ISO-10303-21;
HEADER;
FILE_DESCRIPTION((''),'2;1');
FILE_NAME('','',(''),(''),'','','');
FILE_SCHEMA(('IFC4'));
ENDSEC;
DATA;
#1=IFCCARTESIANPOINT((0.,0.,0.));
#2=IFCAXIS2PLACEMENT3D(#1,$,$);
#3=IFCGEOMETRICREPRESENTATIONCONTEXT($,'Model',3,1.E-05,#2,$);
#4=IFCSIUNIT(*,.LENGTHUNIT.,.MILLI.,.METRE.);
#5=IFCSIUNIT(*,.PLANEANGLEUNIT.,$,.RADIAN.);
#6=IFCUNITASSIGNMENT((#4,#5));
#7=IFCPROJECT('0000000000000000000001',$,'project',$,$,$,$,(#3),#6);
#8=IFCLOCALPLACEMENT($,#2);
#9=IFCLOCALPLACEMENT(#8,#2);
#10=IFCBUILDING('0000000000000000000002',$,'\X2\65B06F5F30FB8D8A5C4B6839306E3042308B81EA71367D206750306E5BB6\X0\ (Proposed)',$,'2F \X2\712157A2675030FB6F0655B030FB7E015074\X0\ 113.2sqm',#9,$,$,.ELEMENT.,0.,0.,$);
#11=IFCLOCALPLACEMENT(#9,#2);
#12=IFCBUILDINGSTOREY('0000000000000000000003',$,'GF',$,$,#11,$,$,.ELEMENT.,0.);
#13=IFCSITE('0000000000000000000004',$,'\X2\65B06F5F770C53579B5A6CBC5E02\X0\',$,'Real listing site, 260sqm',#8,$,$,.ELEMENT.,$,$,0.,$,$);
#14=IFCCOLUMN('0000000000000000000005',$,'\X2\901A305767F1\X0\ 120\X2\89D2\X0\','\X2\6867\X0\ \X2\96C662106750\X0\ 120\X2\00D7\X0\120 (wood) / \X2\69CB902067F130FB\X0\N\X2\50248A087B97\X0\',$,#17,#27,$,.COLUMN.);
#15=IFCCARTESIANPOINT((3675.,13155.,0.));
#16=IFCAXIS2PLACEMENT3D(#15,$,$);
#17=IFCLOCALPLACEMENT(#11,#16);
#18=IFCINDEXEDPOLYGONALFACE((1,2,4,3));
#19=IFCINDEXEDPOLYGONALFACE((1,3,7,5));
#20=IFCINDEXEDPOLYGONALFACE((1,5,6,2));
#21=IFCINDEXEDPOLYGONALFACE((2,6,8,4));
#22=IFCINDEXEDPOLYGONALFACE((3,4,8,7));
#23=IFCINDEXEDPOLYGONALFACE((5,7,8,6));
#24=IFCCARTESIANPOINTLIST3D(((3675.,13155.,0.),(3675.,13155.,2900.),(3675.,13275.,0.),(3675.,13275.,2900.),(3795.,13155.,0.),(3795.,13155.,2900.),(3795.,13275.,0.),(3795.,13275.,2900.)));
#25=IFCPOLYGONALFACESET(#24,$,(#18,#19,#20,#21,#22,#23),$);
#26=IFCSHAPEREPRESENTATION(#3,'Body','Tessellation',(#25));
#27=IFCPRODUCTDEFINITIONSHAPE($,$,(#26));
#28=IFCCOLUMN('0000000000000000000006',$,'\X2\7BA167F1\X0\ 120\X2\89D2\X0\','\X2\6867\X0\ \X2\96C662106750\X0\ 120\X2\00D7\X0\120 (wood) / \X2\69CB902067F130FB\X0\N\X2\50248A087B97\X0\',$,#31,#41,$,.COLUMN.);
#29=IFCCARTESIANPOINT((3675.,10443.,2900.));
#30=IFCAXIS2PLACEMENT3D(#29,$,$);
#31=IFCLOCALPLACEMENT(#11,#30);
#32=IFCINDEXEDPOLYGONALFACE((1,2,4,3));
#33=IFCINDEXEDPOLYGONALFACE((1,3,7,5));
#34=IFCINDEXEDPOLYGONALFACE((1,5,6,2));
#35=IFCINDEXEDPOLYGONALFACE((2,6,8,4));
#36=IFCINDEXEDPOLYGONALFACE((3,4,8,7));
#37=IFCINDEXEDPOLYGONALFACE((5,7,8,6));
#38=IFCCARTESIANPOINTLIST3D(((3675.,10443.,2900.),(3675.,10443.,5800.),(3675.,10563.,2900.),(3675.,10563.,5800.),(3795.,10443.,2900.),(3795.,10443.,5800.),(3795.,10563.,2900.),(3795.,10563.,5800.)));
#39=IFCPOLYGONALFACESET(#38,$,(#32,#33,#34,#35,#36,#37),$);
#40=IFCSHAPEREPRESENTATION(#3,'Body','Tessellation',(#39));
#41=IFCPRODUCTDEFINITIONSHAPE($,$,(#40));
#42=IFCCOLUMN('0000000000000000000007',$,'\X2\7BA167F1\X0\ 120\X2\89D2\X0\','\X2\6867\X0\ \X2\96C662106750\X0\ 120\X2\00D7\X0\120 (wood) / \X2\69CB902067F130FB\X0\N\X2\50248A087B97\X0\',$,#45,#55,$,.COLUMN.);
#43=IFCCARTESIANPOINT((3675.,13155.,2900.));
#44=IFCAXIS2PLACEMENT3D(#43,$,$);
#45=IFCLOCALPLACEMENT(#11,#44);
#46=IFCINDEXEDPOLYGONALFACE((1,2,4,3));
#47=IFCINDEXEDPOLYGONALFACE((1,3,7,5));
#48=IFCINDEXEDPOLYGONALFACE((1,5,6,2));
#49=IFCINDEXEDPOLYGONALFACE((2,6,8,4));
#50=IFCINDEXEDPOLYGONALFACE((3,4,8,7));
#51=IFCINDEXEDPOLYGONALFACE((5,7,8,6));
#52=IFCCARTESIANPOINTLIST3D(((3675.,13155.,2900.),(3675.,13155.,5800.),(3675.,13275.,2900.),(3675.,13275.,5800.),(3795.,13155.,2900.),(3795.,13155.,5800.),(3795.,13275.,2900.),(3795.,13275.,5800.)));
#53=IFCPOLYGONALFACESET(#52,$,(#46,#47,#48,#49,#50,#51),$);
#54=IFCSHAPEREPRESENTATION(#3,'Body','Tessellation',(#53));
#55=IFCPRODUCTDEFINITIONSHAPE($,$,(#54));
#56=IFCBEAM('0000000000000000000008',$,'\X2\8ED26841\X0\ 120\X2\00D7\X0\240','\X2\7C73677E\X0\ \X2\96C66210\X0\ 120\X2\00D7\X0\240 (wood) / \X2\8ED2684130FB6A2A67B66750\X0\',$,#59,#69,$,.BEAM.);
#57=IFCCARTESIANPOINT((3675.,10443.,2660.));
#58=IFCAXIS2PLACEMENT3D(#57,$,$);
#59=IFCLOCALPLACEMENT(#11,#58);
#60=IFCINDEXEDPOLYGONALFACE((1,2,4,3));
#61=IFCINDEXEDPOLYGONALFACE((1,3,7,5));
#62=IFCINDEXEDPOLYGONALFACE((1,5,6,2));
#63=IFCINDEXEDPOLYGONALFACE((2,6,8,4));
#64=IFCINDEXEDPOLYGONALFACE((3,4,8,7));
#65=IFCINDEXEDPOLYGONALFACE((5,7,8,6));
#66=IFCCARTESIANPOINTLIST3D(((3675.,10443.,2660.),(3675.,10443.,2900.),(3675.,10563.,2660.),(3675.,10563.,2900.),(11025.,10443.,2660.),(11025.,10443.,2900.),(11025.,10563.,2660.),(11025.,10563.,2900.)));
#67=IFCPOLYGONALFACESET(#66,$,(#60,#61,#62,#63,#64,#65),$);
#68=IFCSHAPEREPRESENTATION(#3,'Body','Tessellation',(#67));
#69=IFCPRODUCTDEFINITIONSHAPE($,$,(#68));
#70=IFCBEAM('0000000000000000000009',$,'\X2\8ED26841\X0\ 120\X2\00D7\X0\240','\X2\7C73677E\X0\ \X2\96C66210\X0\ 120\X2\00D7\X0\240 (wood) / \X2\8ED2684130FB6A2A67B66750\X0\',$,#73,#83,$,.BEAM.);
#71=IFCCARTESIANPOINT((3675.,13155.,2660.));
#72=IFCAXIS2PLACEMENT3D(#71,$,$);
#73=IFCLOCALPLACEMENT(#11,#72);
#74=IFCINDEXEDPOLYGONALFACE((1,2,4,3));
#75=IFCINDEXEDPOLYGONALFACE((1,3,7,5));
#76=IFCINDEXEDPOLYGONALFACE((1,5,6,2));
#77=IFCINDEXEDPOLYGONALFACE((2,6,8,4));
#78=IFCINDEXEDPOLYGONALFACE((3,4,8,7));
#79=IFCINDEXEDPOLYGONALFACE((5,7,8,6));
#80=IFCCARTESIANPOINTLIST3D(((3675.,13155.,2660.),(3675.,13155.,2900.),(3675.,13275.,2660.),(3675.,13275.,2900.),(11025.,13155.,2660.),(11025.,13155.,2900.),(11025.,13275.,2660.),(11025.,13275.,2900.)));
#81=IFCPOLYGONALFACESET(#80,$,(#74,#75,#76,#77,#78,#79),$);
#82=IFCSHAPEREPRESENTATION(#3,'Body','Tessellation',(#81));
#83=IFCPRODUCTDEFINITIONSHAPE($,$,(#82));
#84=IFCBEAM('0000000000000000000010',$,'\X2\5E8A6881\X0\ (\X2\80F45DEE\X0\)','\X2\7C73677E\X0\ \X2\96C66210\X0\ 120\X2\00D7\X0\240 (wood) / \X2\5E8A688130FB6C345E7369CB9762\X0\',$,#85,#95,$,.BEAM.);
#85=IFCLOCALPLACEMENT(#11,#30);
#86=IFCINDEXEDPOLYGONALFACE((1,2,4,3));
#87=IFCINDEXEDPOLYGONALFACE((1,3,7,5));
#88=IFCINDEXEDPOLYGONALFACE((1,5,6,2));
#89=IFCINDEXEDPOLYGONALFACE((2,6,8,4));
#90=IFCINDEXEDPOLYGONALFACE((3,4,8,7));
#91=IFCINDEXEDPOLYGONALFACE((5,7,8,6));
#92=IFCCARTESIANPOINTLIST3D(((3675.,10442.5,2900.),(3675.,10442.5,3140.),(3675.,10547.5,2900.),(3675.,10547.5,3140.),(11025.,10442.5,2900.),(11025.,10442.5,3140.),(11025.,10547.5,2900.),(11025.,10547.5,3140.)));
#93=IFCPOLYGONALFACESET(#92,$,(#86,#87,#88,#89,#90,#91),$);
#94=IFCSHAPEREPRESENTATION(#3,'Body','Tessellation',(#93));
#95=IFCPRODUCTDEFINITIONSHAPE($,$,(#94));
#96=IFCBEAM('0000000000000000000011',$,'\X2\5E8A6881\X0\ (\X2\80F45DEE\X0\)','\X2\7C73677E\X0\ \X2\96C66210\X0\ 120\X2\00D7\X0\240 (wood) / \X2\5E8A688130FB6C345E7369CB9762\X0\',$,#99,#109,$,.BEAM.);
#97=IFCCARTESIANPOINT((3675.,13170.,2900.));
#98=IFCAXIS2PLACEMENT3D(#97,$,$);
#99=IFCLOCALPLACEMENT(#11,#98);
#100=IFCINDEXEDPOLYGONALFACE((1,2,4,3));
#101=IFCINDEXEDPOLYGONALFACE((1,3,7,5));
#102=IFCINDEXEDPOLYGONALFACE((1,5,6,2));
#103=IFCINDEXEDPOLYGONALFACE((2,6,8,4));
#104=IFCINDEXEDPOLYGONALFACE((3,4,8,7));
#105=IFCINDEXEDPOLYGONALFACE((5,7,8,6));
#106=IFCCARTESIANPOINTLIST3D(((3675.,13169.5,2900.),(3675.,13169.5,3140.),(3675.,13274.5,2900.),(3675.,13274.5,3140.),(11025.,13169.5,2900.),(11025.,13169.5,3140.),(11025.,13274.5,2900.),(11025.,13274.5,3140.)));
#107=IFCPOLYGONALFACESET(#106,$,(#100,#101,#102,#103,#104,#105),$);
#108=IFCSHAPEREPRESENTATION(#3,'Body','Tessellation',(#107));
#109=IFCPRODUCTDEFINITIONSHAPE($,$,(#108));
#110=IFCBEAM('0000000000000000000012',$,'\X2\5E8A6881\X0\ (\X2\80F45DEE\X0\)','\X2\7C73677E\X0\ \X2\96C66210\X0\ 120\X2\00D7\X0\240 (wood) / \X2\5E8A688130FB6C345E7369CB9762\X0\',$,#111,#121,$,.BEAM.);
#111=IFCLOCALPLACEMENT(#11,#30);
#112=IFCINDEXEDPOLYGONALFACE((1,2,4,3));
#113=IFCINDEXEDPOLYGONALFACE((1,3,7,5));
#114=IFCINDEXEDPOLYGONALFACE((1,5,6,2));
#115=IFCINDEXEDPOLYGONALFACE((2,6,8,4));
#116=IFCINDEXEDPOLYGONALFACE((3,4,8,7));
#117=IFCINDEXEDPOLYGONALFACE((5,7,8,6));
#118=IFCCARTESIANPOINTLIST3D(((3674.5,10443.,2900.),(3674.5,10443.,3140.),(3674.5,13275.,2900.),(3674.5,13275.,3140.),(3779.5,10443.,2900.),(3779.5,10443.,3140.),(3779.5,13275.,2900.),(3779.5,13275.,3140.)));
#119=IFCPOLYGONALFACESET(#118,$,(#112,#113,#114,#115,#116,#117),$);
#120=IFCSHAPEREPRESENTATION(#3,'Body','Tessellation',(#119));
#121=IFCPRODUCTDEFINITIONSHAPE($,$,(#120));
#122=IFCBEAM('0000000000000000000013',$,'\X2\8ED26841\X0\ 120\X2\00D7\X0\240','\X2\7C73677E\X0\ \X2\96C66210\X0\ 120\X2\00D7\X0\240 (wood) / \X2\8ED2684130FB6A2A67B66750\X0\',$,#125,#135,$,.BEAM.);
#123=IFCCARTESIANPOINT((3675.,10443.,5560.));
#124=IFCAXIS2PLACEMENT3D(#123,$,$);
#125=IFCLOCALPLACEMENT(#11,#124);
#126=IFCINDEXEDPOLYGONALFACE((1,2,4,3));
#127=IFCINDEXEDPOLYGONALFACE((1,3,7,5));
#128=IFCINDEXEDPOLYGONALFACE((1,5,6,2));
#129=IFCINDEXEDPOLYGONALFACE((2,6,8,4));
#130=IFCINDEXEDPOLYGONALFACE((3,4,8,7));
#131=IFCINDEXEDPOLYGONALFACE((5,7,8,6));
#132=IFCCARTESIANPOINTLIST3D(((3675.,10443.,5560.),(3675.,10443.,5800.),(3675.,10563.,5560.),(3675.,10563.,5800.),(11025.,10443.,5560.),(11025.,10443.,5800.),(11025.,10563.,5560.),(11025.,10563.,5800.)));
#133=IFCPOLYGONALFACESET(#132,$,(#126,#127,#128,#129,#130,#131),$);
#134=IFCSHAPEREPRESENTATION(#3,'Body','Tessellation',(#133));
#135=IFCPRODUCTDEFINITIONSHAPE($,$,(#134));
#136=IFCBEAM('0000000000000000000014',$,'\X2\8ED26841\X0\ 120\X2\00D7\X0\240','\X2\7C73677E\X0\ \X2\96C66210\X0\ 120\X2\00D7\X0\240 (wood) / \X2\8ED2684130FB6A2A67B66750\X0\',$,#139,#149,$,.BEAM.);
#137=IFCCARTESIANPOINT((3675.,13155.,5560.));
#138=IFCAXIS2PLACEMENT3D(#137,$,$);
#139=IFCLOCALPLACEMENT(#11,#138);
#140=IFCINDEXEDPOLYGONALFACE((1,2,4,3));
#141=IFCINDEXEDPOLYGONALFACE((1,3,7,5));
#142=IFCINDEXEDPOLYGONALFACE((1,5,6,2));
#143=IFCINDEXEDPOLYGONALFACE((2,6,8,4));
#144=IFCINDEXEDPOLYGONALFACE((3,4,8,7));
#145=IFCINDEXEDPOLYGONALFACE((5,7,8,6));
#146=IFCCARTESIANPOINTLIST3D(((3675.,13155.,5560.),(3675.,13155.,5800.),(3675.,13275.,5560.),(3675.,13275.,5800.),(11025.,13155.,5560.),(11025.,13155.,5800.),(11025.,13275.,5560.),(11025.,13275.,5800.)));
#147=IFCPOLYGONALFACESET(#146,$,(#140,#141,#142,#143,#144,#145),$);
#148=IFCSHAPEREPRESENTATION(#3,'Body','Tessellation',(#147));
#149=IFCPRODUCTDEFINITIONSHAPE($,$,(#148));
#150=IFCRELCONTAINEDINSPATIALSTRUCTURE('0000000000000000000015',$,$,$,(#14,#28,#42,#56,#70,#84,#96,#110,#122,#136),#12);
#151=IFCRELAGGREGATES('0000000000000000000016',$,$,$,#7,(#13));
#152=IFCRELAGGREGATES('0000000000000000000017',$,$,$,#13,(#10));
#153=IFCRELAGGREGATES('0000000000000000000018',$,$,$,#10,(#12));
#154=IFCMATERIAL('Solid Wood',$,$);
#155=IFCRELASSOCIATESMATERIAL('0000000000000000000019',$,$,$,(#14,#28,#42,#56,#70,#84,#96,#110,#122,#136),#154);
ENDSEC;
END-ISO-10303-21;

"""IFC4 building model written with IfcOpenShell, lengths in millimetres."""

from ifc_helpers import new_model, si_unit, frame, frame_2d, origin, place, context, project, spatial, rectangle, extrude, material, element, save


model = new_model("IFC4")

# Units and contexts
model_context = context("Model", 3, precision=1e-05, world=origin())
ifc_project = project(units=[si_unit("LENGTHUNIT", "METRE", prefix="MILLI"), si_unit("PLANEANGLEUNIT", "RADIAN")], contexts=[model_context])

# Site, building, storey
site_placement = place(None, origin())
site = spatial("IfcSite", under=ifc_project, at=site_placement, Name="新潟県南魚沼市", ObjectType="Real listing site, 260sqm", CompositionType="ELEMENT", RefElevation=0.0)
building_placement = place(site_placement, origin())
building = spatial("IfcBuilding", under=site, at=building_placement, Name="新潟・越屋根のある自然素材の家 (Proposed)", ObjectType="2F 無垢材・漆喰・縁側 113.2sqm", CompositionType="ELEMENT", ElevationOfRefHeight=0.0, ElevationOfTerrain=0.0)
storey_placement = place(building_placement, origin())
storey = spatial("IfcBuildingStorey", under=building, at=storey_placement, Name="GF", CompositionType="ELEMENT", Elevation=0.0)

# Columns
ifc_material_1 = material(Name="Solid Wood")
column_1_placement = place(storey_placement, frame((3675.0, 13155.0, 0.0)))
element("IfcColumn", 1, at=column_1_placement, inside=storey, material=ifc_material_1, Name="通し柱 120角", Description="桧 集成材 120×120 (wood) / 構造柱・N値計算", PredefinedType="COLUMN", context=model_context, shape_type="SweptSolid", body=[
    extrude(rectangle(XDim=120.0, YDim=120.0, at=frame_2d((60.0, 60.0))), frame((3675.0, 13155.0, 0.0)), (0.0, 0.0, 1.0), 2900.0),
])
column_2_placement = place(storey_placement, frame((3675.0, 10443.0, 2900.0)))
element("IfcColumn", 2, at=column_2_placement, inside=storey, material=ifc_material_1, Name="管柱 120角", Description="桧 集成材 120×120 (wood) / 構造柱・N値計算", PredefinedType="COLUMN", context=model_context, shape_type="SweptSolid", body=[
    extrude(rectangle(XDim=120.0, YDim=120.0, at=frame_2d((60.0, 60.0))), frame((3675.0, 10443.0, 2900.0)), (0.0, 0.0, 1.0), 2900.0),
])
column_3_placement = place(storey_placement, frame((3675.0, 13155.0, 2900.0)))
element("IfcColumn", 3, at=column_3_placement, inside=storey, material=ifc_material_1, Name="管柱 120角", Description="桧 集成材 120×120 (wood) / 構造柱・N値計算", PredefinedType="COLUMN", context=model_context, shape_type="SweptSolid", body=[
    extrude(rectangle(XDim=120.0, YDim=120.0, at=frame_2d((60.0, 60.0))), frame((3675.0, 13155.0, 2900.0)), (0.0, 0.0, 1.0), 2900.0),
])

# Beams
beam_1_placement = place(storey_placement, frame((3675.0, 10443.0, 2660.0)))
element("IfcBeam", 4, at=beam_1_placement, inside=storey, material=ifc_material_1, Name="軒桁 120×240", Description="米松 集成 120×240 (wood) / 軒桁・横架材", PredefinedType="BEAM", context=model_context, shape_type="SweptSolid", body=[
    extrude(rectangle(XDim=7350.0, YDim=120.0, at=frame_2d((3675.0, 60.0))), frame((3675.0, 10443.0, 2660.0)), (0.0, 0.0, 1.0), 240.0),
])
beam_2_placement = place(storey_placement, frame((3675.0, 13155.0, 2660.0)))
element("IfcBeam", 5, at=beam_2_placement, inside=storey, material=ifc_material_1, Name="軒桁 120×240", Description="米松 集成 120×240 (wood) / 軒桁・横架材", PredefinedType="BEAM", context=model_context, shape_type="SweptSolid", body=[
    extrude(rectangle(XDim=7350.0, YDim=120.0, at=frame_2d((3675.0, 60.0))), frame((3675.0, 13155.0, 2660.0)), (0.0, 0.0, 1.0), 240.0),
])
beam_3_placement = place(storey_placement, frame((3675.0, 10443.0, 2900.0)))
element("IfcBeam", 6, at=beam_3_placement, inside=storey, material=ifc_material_1, Name="床梁 (胴差)", Description="米松 集成 120×240 (wood) / 床梁・水平構面", PredefinedType="BEAM", context=model_context, shape_type="SweptSolid", body=[
    extrude(rectangle(XDim=7350.0, YDim=105.0, at=frame_2d((3675.0, 52.0))), frame((3675.0, 10443.0, 2900.0)), (0.0, 0.0, 1.0), 240.0),
])
beam_4_placement = place(storey_placement, frame((3675.0, 13170.0, 2900.0)))
element("IfcBeam", 7, at=beam_4_placement, inside=storey, material=ifc_material_1, Name="床梁 (胴差)", Description="米松 集成 120×240 (wood) / 床梁・水平構面", PredefinedType="BEAM", context=model_context, shape_type="SweptSolid", body=[
    extrude(rectangle(XDim=7350.0, YDim=105.0, at=frame_2d((3675.0, 52.0))), frame((3675.0, 13170.0, 2900.0)), (0.0, 0.0, 1.0), 240.0),
])
beam_5_placement = place(storey_placement, frame((3675.0, 10443.0, 2900.0)))
element("IfcBeam", 8, at=beam_5_placement, inside=storey, material=ifc_material_1, Name="床梁 (胴差)", Description="米松 集成 120×240 (wood) / 床梁・水平構面", PredefinedType="BEAM", context=model_context, shape_type="SweptSolid", body=[
    extrude(rectangle(XDim=105.0, YDim=2832.0, at=frame_2d((52.0, 1416.0))), frame((3675.0, 10443.0, 2900.0)), (0.0, 0.0, 1.0), 240.0),
])
beam_6_placement = place(storey_placement, frame((3675.0, 10443.0, 5560.0)))
element("IfcBeam", 9, at=beam_6_placement, inside=storey, material=ifc_material_1, Name="軒桁 120×240", Description="米松 集成 120×240 (wood) / 軒桁・横架材", PredefinedType="BEAM", context=model_context, shape_type="SweptSolid", body=[
    extrude(rectangle(XDim=7350.0, YDim=120.0, at=frame_2d((3675.0, 60.0))), frame((3675.0, 10443.0, 5560.0)), (0.0, 0.0, 1.0), 240.0),
])
beam_7_placement = place(storey_placement, frame((3675.0, 13155.0, 5560.0)))
element("IfcBeam", 10, at=beam_7_placement, inside=storey, material=ifc_material_1, Name="軒桁 120×240", Description="米松 集成 120×240 (wood) / 軒桁・横架材", PredefinedType="BEAM", context=model_context, shape_type="SweptSolid", body=[
    extrude(rectangle(XDim=7350.0, YDim=120.0, at=frame_2d((3675.0, 60.0))), frame((3675.0, 13155.0, 5560.0)), (0.0, 0.0, 1.0), 240.0),
])

save(model, "model.ifc")
